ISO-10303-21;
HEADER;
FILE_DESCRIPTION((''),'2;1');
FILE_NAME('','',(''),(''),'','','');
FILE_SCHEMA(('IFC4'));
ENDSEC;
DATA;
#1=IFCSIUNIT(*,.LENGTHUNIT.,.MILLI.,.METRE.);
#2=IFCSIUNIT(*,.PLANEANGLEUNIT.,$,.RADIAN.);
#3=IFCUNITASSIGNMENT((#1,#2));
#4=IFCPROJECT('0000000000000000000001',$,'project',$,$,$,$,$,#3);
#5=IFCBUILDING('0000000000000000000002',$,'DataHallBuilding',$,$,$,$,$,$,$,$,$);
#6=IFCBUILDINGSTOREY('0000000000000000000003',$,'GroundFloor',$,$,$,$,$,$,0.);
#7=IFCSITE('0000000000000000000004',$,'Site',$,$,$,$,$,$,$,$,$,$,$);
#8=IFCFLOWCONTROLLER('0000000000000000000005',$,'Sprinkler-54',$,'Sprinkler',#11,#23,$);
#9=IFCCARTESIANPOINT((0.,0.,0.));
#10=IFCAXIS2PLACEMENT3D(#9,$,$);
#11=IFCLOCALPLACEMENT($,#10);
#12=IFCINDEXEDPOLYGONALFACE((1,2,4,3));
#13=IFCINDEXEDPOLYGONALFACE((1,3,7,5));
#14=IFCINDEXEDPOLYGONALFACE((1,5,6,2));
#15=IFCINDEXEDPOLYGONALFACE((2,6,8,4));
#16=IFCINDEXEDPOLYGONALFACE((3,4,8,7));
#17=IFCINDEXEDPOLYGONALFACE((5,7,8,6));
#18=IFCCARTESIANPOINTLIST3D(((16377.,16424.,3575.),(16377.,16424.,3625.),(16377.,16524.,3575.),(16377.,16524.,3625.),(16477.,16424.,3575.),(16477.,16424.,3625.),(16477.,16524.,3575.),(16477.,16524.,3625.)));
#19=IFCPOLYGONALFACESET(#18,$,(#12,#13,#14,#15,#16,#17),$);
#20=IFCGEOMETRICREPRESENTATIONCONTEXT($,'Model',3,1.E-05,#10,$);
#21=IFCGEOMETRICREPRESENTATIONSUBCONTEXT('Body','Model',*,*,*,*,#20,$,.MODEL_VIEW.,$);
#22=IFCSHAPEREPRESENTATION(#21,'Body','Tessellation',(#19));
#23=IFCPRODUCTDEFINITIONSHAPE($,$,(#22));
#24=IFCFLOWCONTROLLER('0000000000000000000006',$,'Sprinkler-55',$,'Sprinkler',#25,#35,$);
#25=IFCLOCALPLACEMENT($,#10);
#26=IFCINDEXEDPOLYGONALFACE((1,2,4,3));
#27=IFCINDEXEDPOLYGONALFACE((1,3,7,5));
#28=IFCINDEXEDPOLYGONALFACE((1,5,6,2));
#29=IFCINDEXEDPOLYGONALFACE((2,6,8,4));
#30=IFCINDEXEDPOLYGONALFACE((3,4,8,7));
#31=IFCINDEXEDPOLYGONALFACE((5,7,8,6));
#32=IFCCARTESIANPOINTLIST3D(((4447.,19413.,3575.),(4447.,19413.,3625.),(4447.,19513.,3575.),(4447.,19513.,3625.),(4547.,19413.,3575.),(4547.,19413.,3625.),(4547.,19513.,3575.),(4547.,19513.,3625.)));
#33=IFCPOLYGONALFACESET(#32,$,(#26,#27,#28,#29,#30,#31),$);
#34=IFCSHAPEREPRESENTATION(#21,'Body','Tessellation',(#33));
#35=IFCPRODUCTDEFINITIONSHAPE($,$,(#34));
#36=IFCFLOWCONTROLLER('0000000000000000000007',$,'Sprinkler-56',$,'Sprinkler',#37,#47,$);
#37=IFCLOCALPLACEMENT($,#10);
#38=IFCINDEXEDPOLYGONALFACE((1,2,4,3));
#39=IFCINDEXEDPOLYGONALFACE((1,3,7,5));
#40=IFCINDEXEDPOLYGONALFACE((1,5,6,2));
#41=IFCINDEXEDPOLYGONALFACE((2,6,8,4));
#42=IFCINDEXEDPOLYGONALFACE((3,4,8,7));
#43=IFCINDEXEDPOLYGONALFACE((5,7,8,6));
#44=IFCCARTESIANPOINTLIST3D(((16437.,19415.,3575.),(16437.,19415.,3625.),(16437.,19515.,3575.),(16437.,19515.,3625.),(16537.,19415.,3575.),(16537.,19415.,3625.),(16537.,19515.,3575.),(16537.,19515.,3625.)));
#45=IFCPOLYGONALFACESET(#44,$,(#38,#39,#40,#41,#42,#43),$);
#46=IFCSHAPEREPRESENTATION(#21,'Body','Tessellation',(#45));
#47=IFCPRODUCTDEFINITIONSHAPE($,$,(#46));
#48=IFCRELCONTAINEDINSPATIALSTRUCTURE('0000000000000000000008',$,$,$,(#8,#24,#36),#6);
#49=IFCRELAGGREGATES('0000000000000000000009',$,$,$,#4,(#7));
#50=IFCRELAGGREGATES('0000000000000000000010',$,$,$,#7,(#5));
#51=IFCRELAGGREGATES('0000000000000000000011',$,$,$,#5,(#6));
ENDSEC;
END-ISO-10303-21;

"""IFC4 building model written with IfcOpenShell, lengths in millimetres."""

from ifc_helpers import new_model, si_unit, frame, origin, place, context, subcontext, project, spatial, rectangle, extrude, element, save


model = new_model("IFC4")

# Units and contexts
model_context = context("Model", 3, precision=1e-05, world=origin())
body_context = subcontext(model_context, "Body", "Model", "MODEL_VIEW")
ifc_project = project(units=[si_unit("LENGTHUNIT", "METRE", prefix="MILLI"), si_unit("PLANEANGLEUNIT", "RADIAN")])

# Site, building, storey
site = spatial("IfcSite", under=ifc_project, Name="Site")
building = spatial("IfcBuilding", under=site, Name="DataHallBuilding")
storey = spatial("IfcBuildingStorey", under=building, Name="GroundFloor", Elevation=0.0)

# Flow controllers
flow_controller_1_placement = place(None, origin())
element("IfcFlowController", 1, at=flow_controller_1_placement, inside=storey, Name="Sprinkler-54", ObjectType="Sprinkler", context=body_context, shape_type="SweptSolid", body=[
    extrude(rectangle(XDim=100.0, YDim=100.0), frame((16427.0, 16474.0, 3575.0), z_axis=(0.0, 0.0, 1.0), x_axis=(1.0, 0.0, 0.0)), (0.0, 0.0, 1.0), 50.0),
])
flow_controller_2_placement = place(None, origin())
element("IfcFlowController", 2, at=flow_controller_2_placement, inside=storey, Name="Sprinkler-55", ObjectType="Sprinkler", context=body_context, shape_type="SweptSolid", body=[
    extrude(rectangle(XDim=100.0, YDim=100.0), frame((4497.0, 19463.0, 3575.0), z_axis=(0.0, 0.0, 1.0), x_axis=(1.0, 0.0, 0.0)), (0.0, 0.0, 1.0), 50.0),
])
flow_controller_3_placement = place(None, origin())
element("IfcFlowController", 3, at=flow_controller_3_placement, inside=storey, Name="Sprinkler-56", ObjectType="Sprinkler", context=body_context, shape_type="SweptSolid", body=[
    extrude(rectangle(XDim=100.0, YDim=100.0), frame((16487.0, 19465.0, 3575.0), z_axis=(0.0, 0.0, 1.0), x_axis=(1.0, 0.0, 0.0)), (0.0, 0.0, 1.0), 50.0),
])

save(model, "model.ifc")
